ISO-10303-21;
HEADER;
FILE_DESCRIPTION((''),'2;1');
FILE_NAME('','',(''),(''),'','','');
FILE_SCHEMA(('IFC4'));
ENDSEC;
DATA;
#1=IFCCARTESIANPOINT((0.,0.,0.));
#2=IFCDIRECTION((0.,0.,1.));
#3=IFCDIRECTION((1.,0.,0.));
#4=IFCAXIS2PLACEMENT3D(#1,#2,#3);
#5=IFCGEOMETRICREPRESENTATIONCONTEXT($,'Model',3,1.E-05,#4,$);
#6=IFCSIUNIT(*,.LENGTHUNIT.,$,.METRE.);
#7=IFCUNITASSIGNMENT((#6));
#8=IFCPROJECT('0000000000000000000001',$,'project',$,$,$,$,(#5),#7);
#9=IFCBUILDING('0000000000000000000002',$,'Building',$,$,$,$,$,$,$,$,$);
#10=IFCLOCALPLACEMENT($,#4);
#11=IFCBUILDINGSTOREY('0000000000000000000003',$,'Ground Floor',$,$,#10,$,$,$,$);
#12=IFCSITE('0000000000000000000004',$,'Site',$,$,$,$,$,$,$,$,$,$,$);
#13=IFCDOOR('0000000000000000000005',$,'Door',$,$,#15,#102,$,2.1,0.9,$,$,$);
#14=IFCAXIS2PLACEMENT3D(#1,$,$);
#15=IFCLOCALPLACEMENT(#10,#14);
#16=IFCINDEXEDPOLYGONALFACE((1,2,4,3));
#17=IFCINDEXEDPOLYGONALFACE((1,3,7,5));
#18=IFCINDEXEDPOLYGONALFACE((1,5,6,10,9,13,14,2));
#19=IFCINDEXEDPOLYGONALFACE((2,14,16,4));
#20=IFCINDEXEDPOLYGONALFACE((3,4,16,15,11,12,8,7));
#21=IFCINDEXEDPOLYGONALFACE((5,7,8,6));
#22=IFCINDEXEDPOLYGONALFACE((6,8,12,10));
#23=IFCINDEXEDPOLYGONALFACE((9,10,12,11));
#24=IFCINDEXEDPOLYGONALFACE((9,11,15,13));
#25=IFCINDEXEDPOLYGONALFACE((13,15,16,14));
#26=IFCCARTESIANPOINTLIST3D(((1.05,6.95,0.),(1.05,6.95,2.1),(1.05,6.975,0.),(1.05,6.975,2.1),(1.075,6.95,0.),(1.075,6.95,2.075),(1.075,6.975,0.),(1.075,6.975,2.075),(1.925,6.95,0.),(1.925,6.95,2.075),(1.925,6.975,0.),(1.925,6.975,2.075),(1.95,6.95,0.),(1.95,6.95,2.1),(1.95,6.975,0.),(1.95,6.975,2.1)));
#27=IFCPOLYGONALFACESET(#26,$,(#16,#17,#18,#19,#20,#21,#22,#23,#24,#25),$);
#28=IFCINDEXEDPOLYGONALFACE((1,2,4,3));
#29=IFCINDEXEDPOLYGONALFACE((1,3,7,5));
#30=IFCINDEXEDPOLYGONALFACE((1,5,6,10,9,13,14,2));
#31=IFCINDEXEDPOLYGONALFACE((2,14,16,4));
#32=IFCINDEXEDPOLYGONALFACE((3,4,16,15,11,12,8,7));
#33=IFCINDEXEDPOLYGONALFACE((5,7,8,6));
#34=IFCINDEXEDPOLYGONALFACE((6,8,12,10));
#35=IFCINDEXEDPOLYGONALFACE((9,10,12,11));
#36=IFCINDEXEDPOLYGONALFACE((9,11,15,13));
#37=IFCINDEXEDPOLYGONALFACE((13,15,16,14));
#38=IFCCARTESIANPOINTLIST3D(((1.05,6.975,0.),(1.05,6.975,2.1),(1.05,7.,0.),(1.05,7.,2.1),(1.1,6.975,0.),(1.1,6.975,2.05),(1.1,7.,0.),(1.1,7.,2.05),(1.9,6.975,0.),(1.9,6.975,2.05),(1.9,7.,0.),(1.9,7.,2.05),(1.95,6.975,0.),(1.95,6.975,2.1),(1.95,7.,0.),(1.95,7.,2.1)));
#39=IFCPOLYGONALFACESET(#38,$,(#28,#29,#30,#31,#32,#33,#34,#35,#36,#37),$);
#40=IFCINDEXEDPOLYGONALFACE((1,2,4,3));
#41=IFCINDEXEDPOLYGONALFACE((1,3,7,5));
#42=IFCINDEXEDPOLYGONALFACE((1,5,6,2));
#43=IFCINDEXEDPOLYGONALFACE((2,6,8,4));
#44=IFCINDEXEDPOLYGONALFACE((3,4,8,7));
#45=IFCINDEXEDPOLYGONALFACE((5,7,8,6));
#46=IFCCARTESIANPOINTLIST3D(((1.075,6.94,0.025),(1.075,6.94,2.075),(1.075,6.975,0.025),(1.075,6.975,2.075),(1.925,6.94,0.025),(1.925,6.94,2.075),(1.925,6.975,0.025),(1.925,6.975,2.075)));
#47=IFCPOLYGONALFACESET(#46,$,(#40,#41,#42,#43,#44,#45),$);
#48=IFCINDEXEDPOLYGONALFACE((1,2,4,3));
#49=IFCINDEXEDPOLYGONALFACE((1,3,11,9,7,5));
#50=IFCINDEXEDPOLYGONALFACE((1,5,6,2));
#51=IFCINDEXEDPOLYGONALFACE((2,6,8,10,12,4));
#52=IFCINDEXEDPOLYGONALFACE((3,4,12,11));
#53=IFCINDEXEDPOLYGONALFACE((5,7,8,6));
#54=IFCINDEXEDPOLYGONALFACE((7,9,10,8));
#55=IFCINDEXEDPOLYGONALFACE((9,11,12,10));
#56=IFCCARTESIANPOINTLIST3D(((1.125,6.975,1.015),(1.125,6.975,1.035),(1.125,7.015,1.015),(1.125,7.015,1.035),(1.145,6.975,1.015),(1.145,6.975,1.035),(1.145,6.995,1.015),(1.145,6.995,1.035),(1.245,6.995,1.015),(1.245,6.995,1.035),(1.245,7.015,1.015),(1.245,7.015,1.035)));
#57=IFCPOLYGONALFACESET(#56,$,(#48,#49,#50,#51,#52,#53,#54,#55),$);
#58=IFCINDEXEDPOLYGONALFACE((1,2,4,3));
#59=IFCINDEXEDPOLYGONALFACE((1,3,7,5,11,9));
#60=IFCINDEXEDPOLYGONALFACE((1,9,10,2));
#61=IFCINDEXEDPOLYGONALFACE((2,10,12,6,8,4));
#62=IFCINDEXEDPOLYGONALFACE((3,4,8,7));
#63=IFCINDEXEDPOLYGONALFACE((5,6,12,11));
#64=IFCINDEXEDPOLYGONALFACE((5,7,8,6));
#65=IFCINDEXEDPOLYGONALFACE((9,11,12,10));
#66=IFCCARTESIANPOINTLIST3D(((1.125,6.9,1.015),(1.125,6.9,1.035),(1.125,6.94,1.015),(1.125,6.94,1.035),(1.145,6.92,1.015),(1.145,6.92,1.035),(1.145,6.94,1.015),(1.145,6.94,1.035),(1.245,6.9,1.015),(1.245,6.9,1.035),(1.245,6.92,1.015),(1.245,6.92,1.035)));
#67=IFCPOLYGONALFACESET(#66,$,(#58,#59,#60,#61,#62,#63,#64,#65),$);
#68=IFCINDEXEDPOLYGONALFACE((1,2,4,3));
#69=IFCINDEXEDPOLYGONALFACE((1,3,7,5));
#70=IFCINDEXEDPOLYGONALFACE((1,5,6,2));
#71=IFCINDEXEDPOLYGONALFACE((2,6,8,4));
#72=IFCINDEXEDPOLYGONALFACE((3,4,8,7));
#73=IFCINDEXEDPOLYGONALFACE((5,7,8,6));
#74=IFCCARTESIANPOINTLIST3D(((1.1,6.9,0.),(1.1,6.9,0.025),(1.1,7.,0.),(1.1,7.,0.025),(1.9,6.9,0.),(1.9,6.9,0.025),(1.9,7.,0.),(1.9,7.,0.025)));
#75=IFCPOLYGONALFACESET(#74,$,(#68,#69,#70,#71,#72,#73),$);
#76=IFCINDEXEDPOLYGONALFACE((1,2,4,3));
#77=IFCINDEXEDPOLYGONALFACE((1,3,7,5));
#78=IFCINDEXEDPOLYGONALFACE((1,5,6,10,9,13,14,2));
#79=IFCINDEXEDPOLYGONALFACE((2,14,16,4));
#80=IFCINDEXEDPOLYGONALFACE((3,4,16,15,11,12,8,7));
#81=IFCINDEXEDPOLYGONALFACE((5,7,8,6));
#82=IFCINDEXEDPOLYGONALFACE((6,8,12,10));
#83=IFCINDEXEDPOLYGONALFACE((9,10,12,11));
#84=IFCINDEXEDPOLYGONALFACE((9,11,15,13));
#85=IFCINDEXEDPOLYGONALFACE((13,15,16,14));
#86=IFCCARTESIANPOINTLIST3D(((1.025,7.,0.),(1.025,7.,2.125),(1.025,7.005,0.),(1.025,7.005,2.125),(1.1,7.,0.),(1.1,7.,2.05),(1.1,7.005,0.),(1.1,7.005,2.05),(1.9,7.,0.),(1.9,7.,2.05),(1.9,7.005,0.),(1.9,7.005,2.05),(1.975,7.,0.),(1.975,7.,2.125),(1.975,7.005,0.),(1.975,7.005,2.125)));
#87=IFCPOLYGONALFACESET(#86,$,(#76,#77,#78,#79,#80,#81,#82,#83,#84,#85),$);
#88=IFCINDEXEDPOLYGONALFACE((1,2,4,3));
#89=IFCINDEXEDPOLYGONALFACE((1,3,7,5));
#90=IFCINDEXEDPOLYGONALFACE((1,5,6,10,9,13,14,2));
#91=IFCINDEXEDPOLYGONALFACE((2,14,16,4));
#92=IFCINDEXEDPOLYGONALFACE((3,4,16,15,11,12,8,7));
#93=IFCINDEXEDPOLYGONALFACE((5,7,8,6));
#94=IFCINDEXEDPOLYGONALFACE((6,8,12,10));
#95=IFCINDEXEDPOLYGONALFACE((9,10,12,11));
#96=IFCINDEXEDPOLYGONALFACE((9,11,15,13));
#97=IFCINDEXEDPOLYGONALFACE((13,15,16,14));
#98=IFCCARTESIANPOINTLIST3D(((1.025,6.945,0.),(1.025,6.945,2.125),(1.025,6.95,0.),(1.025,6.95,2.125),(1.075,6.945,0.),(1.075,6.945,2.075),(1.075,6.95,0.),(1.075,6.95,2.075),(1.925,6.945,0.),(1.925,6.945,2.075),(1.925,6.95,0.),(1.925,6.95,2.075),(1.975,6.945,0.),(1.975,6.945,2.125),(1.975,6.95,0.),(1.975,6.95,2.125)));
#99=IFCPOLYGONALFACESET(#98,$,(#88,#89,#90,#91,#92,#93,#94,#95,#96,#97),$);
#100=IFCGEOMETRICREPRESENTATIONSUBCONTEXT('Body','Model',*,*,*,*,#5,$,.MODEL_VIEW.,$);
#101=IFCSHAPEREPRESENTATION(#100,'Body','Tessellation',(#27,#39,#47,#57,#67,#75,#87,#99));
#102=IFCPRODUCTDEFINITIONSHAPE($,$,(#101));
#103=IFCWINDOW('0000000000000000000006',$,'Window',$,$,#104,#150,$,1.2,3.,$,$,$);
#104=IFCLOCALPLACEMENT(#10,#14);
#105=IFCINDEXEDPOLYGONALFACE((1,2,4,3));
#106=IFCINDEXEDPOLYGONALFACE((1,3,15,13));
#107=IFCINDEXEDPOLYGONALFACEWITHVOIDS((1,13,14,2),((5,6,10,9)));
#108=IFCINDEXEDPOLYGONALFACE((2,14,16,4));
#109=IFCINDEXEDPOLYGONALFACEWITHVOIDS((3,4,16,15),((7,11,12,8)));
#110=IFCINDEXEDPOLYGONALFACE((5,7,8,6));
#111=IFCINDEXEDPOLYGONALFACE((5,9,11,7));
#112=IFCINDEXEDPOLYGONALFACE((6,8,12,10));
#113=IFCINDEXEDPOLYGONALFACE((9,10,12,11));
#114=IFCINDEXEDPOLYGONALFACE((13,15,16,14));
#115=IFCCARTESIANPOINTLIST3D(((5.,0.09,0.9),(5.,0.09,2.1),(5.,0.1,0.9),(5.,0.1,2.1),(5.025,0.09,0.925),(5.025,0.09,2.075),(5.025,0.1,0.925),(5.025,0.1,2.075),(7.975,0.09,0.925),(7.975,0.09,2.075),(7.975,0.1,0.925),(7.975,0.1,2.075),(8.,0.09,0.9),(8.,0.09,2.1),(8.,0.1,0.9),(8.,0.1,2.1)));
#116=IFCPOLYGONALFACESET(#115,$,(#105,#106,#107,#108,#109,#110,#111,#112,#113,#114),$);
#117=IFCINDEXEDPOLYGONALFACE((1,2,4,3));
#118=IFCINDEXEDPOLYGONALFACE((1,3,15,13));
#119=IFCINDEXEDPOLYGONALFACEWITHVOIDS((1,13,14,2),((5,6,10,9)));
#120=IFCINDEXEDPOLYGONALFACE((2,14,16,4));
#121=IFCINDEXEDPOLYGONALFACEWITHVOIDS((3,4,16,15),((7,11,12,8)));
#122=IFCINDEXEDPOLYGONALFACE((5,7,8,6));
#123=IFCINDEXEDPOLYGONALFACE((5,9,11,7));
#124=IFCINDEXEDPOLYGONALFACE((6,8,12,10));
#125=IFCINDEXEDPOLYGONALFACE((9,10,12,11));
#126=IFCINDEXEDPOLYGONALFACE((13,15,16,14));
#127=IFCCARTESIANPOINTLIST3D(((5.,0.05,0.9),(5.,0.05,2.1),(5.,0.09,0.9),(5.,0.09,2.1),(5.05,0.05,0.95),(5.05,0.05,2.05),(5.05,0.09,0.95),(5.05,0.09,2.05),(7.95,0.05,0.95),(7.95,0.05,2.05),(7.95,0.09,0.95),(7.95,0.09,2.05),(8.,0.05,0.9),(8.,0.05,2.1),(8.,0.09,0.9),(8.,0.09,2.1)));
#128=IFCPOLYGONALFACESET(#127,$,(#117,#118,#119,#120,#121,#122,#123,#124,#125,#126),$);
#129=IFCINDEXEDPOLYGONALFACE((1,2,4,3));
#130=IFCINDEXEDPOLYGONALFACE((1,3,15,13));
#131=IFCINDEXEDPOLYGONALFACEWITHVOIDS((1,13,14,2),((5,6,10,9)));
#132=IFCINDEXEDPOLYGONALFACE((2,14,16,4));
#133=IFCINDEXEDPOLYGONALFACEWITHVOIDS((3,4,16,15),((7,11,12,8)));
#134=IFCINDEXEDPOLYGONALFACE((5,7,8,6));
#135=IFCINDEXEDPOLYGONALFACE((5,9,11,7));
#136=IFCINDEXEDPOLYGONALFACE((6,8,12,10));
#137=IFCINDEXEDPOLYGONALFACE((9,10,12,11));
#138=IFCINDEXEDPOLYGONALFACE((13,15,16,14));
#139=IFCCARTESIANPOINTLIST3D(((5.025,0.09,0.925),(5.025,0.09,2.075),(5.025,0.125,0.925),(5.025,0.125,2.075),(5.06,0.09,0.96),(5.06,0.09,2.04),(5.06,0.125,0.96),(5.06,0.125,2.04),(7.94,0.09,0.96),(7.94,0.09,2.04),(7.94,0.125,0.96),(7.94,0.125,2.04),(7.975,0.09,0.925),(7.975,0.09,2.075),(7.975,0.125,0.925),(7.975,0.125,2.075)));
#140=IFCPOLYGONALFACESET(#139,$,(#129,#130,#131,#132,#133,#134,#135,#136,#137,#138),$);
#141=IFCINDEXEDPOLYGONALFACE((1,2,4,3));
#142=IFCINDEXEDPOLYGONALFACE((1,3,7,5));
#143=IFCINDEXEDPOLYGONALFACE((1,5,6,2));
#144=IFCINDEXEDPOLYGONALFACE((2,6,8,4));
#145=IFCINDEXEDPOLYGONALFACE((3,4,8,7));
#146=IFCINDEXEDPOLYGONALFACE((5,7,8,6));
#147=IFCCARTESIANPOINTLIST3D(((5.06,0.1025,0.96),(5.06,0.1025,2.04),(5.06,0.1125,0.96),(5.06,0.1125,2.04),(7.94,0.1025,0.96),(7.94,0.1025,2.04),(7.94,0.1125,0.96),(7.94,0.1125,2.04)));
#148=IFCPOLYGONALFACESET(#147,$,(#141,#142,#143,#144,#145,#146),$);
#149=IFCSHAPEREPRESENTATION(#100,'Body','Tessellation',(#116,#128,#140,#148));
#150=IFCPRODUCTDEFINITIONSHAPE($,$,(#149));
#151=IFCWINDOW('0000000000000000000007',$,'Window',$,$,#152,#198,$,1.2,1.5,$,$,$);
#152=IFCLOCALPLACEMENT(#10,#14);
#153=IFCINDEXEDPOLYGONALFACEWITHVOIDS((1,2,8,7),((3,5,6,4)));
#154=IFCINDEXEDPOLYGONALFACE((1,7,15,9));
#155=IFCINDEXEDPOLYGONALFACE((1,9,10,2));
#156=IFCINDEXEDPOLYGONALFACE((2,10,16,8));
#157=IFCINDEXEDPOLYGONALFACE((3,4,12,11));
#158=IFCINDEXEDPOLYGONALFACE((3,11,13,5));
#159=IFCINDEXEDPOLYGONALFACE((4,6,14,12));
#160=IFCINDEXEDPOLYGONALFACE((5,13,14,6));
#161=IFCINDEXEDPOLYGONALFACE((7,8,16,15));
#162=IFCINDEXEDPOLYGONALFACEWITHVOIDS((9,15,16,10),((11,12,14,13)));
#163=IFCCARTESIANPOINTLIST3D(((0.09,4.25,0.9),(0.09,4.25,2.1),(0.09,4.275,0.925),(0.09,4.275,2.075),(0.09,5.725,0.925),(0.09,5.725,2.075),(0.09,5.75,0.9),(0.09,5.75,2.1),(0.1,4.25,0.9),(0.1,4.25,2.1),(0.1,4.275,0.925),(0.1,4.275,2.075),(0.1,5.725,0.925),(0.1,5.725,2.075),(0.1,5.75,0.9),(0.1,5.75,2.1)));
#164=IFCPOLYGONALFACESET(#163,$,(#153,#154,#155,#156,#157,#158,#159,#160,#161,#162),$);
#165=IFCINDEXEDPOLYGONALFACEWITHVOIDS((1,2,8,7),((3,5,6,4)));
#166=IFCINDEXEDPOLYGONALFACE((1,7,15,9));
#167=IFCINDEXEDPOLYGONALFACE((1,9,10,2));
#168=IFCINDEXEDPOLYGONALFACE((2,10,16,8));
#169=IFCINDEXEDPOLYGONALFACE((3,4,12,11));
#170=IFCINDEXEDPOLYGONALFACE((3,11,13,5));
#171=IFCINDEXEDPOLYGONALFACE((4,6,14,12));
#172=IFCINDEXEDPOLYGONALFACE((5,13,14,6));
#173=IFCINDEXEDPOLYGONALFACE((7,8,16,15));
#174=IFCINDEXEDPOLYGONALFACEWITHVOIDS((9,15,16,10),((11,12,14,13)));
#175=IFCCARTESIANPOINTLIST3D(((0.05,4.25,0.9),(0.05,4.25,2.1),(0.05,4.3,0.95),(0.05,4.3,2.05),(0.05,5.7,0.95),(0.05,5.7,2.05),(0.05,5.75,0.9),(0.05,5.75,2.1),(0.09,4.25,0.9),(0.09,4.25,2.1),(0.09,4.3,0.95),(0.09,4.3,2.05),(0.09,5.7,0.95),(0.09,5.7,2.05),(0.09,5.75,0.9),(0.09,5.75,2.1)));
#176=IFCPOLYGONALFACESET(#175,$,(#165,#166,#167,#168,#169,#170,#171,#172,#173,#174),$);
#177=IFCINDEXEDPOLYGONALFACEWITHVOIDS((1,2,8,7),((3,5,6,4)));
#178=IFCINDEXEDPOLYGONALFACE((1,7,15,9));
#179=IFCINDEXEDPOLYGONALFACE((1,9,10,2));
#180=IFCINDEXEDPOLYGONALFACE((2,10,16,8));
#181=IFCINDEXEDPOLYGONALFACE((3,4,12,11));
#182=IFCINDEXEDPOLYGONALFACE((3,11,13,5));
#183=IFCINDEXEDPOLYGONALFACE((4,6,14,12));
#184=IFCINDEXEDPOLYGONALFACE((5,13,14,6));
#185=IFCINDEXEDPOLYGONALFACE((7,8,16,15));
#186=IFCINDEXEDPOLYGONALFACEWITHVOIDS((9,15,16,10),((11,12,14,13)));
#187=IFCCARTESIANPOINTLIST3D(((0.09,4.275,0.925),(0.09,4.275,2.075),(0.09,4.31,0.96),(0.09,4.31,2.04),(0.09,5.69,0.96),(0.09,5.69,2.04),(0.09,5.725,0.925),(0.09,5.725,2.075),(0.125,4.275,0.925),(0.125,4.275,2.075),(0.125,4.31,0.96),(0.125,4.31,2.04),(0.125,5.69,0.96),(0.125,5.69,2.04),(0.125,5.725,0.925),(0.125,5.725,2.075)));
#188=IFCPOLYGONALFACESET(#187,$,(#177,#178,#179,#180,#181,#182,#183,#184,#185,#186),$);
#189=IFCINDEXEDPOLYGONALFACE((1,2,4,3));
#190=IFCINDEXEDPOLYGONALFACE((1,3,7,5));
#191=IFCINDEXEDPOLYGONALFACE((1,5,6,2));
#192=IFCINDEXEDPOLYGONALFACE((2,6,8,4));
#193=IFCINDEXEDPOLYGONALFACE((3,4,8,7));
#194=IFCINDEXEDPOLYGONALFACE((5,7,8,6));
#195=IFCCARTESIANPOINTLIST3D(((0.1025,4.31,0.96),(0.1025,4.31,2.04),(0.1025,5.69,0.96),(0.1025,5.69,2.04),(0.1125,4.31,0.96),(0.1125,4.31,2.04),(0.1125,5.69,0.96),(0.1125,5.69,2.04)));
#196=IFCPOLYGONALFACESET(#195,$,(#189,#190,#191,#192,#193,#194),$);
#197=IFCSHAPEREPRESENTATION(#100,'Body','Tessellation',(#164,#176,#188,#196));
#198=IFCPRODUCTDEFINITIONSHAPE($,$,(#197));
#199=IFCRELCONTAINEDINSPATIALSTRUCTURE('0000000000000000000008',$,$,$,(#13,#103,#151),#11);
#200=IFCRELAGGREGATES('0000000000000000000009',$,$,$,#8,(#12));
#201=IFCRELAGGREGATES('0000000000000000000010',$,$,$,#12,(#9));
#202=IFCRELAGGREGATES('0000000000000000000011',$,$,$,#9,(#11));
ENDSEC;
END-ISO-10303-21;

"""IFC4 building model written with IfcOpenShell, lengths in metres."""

from ifc_helpers import new_model, si_unit, frame, origin_with_axes, place, context, subcontext, project, spatial, line, indexed_curve, outline, extrude, element, save


model = new_model("IFC4")

# Units and contexts
model_context = context("Model", 3, precision=1e-05, world=origin_with_axes())
body_context = subcontext(model_context, "Body", "Model", "MODEL_VIEW")
ifc_project = project(units=[si_unit("LENGTHUNIT", "METRE")], contexts=[model_context])

# Site, building, storey
site = spatial("IfcSite", under=ifc_project, Name="Site")
building = spatial("IfcBuilding", under=site, Name="Building")
storey_placement = place(None, origin_with_axes())
storey = spatial("IfcBuildingStorey", under=building, at=storey_placement, Name="Ground Floor")

# Door
door_1_placement = place(storey_placement, frame((1.95, 7.0, 0.0), z_axis=(0.0, 0.0, 1.0), x_axis=(-1.0, 0.0, 0.0)))
element("IfcDoor", 1, at=door_1_placement, inside=storey, Name="Door", OverallHeight=2.1, OverallWidth=0.9, context=body_context, shape_type="SweptSolid", body=[
    extrude(outline(indexed_curve([(0.0, 0.0), (0.0, 2.1), (0.9, 2.1), (0.9, 0.0), (0.875, 0.0), (0.875, 2.075), (0.025, 2.075), (0.025, 0.0)], segments=[line(1, 2, 3, 4, 5, 6, 7, 8, 1)])), frame((0.0, 0.025, 0.0), z_axis=(0.0, -1.0, 0.0), x_axis=(1.0, 0.0, 0.0)), (0.0, 0.0, -1.0), 0.025),
    extrude(outline(indexed_curve([(0.0, 0.0), (0.0, 2.1), (0.9, 2.1), (0.9, 0.0), (0.85, 0.0), (0.85, 2.05), (0.05, 2.05), (0.05, 0.0)], segments=[line(1, 2, 3, 4, 5, 6, 7, 8, 1)])), frame((0.0, 0.0, 0.0), z_axis=(0.0, -1.0, 0.0), x_axis=(1.0, 0.0, 0.0)), (0.0, 0.0, -1.0), 0.025),
    extrude(outline(indexed_curve([(0.0, 0.0), (0.85, 0.0), (0.85, 0.035), (0.0, 0.035)], segments=[line(1, 2, 3, 4, 1)])), frame((0.025, 0.025, 0.025), z_axis=(0.0, 0.0, 1.0), x_axis=(1.0, 0.0, 0.0)), (0.0, 0.0, 1.0), 2.05),
    extrude(outline(indexed_curve([(0.0, 0.0), (0.0, -0.04), (-0.12, -0.04), (-0.12, -0.02), (-0.02, -0.02), (-0.02, 0.0)], segments=[line(1, 2, 3, 4, 5, 6, 1)])), frame((0.825, 0.025, 1.015), z_axis=(0.0, 0.0, 1.0), x_axis=(1.0, 0.0, 0.0)), (0.0, 0.0, 1.0), 0.02),
    extrude(outline(indexed_curve([(0.0, 0.0), (0.0, 0.04), (-0.12, 0.04), (-0.12, 0.02), (-0.02, 0.02), (-0.02, 0.0)], segments=[line(1, 2, 3, 4, 5, 6, 1)])), frame((0.825, 0.06, 1.015), z_axis=(0.0, 0.0, 1.0), x_axis=(1.0, 0.0, 0.0)), (0.0, 0.0, 1.0), 0.02),
    extrude(outline(indexed_curve([(0.0, 0.0), (0.8, 0.0), (0.8, 0.1), (0.0, 0.1)], segments=[line(1, 2, 3, 4, 1)])), frame((0.05, 0.0, 0.0), z_axis=(0.0, 0.0, 1.0), x_axis=(1.0, 0.0, 0.0)), (0.0, 0.0, 1.0), 0.025),
    extrude(outline(indexed_curve([(0.0, 0.0), (0.0, 2.125), (0.95, 2.125), (0.95, 0.0), (0.875, 0.0), (0.875, 2.05), (0.075, 2.05), (0.075, 0.0)], segments=[line(1, 2, 3, 4, 5, 6, 7, 8, 1)])), frame((-0.025, -0.005, 0.0), z_axis=(0.0, -1.0, 0.0), x_axis=(1.0, 0.0, 0.0)), (0.0, 0.0, -1.0), 0.005),
    extrude(outline(indexed_curve([(0.0, 0.0), (0.0, 2.125), (0.95, 2.125), (0.95, 0.0), (0.9, 0.0), (0.9, 2.075), (0.05, 2.075), (0.05, 0.0)], segments=[line(1, 2, 3, 4, 5, 6, 7, 8, 1)])), frame((-0.025, 0.05, 0.0), z_axis=(0.0, -1.0, 0.0), x_axis=(1.0, 0.0, 0.0)), (0.0, 0.0, -1.0), 0.005),
])

# Windows
window_1_placement = place(storey_placement, frame((5.0, 0.0, 0.9), z_axis=(0.0, 0.0, 1.0), x_axis=(1.0, 0.0, 0.0)))
element("IfcWindow", 2, at=window_1_placement, inside=storey, Name="Window", OverallHeight=1.2, OverallWidth=3.0, context=body_context, shape_type="SweptSolid", body=[
    extrude(outline(indexed_curve([(0.0, 0.0), (3.0, 0.0), (3.0, 1.2), (0.0, 1.2)], segments=[line(1, 2, 3, 4, 1)]), holes=[indexed_curve([(0.025, 0.025), (2.975, 0.025), (2.975, 1.175), (0.025, 1.175)], segments=[line(1, 2, 3, 4, 1)])]), frame((0.0, 0.09, 0.0), z_axis=(0.0, -1.0, 0.0), x_axis=(1.0, 0.0, 0.0)), (0.0, 0.0, -1.0), 0.01),
    extrude(outline(indexed_curve([(0.0, 0.0), (3.0, 0.0), (3.0, 1.2), (0.0, 1.2)], segments=[line(1, 2, 3, 4, 1)]), holes=[indexed_curve([(0.05, 0.05), (2.95, 0.05), (2.95, 1.15), (0.05, 1.15)], segments=[line(1, 2, 3, 4, 1)])]), frame((0.0, 0.05, 0.0), z_axis=(0.0, -1.0, 0.0), x_axis=(1.0, 0.0, 0.0)), (0.0, 0.0, -1.0), 0.04),
    extrude(outline(indexed_curve([(0.0, 0.0), (2.95, 0.0), (2.95, 1.15), (0.0, 1.15)], segments=[line(1, 2, 3, 4, 1)]), holes=[indexed_curve([(0.035, 0.035), (2.915, 0.035), (2.915, 1.115), (0.035, 1.115)], segments=[line(1, 2, 3, 4, 1)])]), frame((0.025, 0.09, 0.025), z_axis=(0.0, -1.0, 0.0), x_axis=(1.0, 0.0, 0.0)), (0.0, 0.0, -1.0), 0.035),
    extrude(outline(indexed_curve([(0.035, 0.035), (2.915, 0.035), (2.915, 1.115), (0.035, 1.115)], segments=[line(1, 2, 3, 4, 1)])), frame((0.025, 0.1025, 0.025), z_axis=(0.0, -1.0, 0.0), x_axis=(1.0, 0.0, 0.0)), (0.0, 0.0, -1.0), 0.01),
])
window_2_placement = place(storey_placement, frame((0.0, 5.75, 0.9), z_axis=(0.0, 0.0, 1.0), x_axis=(0.0, -1.0, 0.0)))
element("IfcWindow", 3, at=window_2_placement, inside=storey, Name="Window", OverallHeight=1.2, OverallWidth=1.5, context=body_context, shape_type="SweptSolid", body=[
    extrude(outline(indexed_curve([(0.0, 0.0), (1.5, 0.0), (1.5, 1.2), (0.0, 1.2)], segments=[line(1, 2, 3, 4, 1)]), holes=[indexed_curve([(0.025, 0.025), (1.475, 0.025), (1.475, 1.175), (0.025, 1.175)], segments=[line(1, 2, 3, 4, 1)])]), frame((0.0, 0.09, 0.0), z_axis=(0.0, -1.0, 0.0), x_axis=(1.0, 0.0, 0.0)), (0.0, 0.0, -1.0), 0.01),
    extrude(outline(indexed_curve([(0.0, 0.0), (1.5, 0.0), (1.5, 1.2), (0.0, 1.2)], segments=[line(1, 2, 3, 4, 1)]), holes=[indexed_curve([(0.05, 0.05), (1.45, 0.05), (1.45, 1.15), (0.05, 1.15)], segments=[line(1, 2, 3, 4, 1)])]), frame((0.0, 0.05, 0.0), z_axis=(0.0, -1.0, 0.0), x_axis=(1.0, 0.0, 0.0)), (0.0, 0.0, -1.0), 0.04),
    extrude(outline(indexed_curve([(0.0, 0.0), (1.45, 0.0), (1.45, 1.15), (0.0, 1.15)], segments=[line(1, 2, 3, 4, 1)]), holes=[indexed_curve([(0.035, 0.035), (1.415, 0.035), (1.415, 1.115), (0.035, 1.115)], segments=[line(1, 2, 3, 4, 1)])]), frame((0.025, 0.09, 0.025), z_axis=(0.0, -1.0, 0.0), x_axis=(1.0, 0.0, 0.0)), (0.0, 0.0, -1.0), 0.035),
    extrude(outline(indexed_curve([(0.035, 0.035), (1.415, 0.035), (1.415, 1.115), (0.035, 1.115)], segments=[line(1, 2, 3, 4, 1)])), frame((0.025, 0.1025, 0.025), z_axis=(0.0, -1.0, 0.0), x_axis=(1.0, 0.0, 0.0)), (0.0, 0.0, -1.0), 0.01),
])

save(model, "model.ifc")
